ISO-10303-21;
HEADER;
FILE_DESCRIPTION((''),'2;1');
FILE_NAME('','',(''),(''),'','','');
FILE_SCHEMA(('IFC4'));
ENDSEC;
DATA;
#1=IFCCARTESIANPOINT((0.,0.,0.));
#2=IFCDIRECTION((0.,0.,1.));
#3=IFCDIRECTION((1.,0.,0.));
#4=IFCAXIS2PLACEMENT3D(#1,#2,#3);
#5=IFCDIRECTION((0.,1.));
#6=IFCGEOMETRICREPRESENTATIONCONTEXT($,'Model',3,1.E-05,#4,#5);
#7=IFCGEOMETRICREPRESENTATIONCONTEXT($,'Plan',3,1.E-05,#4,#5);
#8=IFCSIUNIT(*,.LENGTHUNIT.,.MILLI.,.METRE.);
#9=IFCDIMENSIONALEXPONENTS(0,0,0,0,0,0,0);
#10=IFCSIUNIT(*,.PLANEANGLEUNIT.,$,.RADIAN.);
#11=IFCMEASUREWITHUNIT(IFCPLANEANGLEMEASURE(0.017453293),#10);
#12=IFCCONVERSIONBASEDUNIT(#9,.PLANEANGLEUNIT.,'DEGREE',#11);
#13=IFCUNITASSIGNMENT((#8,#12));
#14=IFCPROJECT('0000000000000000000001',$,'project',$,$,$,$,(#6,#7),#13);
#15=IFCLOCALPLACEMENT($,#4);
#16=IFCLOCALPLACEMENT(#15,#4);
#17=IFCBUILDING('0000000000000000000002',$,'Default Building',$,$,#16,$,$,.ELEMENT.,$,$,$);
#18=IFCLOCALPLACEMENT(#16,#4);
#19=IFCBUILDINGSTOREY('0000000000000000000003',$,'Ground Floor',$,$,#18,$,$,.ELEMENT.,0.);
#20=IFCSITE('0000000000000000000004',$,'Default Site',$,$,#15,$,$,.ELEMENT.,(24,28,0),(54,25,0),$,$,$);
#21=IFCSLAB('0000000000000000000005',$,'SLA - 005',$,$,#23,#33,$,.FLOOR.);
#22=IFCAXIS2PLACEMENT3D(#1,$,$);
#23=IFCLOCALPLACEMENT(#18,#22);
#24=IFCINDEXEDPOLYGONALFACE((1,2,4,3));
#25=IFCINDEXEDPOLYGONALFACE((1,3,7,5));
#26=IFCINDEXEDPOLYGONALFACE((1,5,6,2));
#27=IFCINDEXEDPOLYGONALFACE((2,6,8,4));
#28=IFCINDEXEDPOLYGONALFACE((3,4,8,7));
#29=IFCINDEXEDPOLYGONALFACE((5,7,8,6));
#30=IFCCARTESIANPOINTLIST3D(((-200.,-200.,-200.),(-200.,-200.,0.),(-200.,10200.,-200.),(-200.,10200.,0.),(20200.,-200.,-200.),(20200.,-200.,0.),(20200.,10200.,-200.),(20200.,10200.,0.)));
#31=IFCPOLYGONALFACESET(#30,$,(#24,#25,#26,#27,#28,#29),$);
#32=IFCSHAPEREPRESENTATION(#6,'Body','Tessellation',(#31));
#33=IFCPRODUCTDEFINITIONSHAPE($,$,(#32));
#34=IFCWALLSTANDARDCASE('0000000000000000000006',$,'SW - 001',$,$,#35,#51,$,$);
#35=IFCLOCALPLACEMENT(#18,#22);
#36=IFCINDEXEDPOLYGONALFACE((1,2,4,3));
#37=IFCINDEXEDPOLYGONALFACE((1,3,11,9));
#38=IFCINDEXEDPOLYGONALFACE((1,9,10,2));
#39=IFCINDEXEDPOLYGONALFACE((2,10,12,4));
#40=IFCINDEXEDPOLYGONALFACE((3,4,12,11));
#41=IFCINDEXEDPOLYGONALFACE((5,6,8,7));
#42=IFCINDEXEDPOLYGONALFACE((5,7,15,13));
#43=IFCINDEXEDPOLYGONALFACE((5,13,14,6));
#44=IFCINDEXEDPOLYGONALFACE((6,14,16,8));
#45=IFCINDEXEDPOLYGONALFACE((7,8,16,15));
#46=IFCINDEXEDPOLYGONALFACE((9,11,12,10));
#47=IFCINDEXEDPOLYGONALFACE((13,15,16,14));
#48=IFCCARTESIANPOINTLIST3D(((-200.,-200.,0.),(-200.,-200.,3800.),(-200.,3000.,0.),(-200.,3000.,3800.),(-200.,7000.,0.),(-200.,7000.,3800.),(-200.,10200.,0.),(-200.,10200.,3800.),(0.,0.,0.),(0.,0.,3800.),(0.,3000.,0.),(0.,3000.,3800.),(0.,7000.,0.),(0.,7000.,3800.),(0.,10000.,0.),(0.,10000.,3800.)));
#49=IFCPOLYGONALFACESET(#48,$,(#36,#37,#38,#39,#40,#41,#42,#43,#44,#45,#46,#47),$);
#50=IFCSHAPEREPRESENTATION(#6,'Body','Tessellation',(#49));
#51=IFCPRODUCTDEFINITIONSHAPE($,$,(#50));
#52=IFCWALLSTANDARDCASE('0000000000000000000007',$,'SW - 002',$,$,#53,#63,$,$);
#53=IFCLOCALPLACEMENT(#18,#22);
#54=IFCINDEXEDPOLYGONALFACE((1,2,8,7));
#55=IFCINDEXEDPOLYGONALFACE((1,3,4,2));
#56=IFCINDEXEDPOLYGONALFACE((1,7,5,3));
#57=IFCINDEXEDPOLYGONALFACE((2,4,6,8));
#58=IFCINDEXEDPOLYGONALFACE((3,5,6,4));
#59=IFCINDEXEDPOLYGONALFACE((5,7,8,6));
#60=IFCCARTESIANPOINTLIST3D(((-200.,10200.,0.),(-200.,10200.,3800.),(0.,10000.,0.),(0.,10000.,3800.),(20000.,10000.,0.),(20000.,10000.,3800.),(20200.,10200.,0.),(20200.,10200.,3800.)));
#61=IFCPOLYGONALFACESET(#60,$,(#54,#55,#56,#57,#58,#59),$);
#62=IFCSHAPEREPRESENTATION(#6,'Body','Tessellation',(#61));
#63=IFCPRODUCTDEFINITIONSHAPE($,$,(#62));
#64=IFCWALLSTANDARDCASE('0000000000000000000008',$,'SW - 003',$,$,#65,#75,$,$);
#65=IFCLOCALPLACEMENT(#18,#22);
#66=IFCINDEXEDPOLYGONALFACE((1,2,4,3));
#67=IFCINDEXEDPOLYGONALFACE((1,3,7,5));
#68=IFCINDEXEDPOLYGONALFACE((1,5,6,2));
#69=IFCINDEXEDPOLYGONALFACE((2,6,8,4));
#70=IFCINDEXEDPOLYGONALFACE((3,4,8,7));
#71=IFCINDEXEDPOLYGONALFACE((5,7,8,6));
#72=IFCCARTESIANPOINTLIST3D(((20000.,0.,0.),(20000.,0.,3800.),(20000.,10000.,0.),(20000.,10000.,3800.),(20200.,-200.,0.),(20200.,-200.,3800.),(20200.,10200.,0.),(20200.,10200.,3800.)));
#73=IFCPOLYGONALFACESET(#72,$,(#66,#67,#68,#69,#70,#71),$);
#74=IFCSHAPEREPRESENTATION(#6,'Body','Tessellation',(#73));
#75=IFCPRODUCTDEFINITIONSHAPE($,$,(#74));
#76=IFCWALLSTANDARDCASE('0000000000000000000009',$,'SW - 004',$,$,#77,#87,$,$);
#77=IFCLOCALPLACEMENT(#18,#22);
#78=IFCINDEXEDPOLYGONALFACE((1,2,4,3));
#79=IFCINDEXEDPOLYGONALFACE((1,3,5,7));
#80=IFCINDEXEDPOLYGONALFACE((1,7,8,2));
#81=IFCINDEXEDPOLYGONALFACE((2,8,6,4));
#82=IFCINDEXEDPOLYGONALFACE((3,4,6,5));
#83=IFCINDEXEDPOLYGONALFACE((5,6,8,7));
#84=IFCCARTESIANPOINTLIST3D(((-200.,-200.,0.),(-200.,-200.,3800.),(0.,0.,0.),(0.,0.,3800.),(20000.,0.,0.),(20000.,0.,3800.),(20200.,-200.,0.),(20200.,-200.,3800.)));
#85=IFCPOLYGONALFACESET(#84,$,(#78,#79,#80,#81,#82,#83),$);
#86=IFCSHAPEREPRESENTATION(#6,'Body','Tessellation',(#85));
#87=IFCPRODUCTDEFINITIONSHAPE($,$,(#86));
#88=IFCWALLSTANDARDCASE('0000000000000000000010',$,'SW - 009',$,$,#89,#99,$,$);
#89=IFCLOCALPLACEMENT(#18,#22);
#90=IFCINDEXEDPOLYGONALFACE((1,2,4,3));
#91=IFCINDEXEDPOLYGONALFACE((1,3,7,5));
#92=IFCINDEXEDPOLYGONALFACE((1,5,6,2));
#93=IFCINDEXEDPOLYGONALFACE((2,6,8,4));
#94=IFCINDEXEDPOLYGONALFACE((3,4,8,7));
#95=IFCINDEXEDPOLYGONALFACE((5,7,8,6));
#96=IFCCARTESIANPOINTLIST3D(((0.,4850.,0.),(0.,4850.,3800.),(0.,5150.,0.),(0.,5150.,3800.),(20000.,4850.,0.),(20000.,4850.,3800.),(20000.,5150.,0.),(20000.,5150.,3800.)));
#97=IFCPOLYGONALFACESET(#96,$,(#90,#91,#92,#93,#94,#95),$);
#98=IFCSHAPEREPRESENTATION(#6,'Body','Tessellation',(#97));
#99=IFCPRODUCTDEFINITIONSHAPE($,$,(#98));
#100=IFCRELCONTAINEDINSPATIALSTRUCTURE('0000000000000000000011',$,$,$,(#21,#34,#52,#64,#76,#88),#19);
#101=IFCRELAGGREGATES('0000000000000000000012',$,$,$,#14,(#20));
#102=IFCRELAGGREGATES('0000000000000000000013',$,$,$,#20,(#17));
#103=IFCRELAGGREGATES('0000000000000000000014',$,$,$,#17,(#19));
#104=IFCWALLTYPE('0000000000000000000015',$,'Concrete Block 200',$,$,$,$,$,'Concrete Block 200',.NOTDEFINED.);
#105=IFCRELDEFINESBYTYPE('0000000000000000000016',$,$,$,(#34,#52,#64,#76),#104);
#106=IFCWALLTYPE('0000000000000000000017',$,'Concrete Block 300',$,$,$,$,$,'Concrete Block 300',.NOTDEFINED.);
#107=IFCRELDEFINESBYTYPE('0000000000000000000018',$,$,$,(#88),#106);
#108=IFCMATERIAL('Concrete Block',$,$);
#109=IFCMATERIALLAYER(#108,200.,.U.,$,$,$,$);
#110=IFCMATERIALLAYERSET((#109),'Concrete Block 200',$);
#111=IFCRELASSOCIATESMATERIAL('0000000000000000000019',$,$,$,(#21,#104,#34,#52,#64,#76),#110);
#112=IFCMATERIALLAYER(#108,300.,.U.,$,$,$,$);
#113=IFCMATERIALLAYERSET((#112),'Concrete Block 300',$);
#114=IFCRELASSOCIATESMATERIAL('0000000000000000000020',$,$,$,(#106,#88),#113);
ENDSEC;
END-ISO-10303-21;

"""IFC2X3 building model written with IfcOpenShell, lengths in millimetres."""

from ifc_helpers import new_model, entity, si_unit, converted_unit, direction, frame, frame_2d, origin_with_axes, place, context, project, spatial, polyline, rectangle, outline, extrude, material, layer, layer_set, layer_usage, type_object, element, save


model = new_model("IFC2X3")

# Units and contexts
model_context = context("Model", 3, precision=1e-05, world=origin_with_axes(), true_north=direction((0.0, 1.0)))
plan_context = context("Plan", 3, precision=1e-05, world=origin_with_axes(), true_north=direction((0.0, 1.0)))
ifc_project = project(units=[si_unit("LENGTHUNIT", "METRE", prefix="MILLI"), converted_unit("PLANEANGLEUNIT", "DEGREE", entity("IfcPlaneAngleMeasure", 0.017453293), si_unit("PLANEANGLEUNIT", "RADIAN"), dimensions=[0, 0, 0, 0, 0, 0, 0])], contexts=[model_context, plan_context])

# Site, building, storey
site_placement = place(None, origin_with_axes())
site = spatial("IfcSite", under=ifc_project, at=site_placement, Name="Default Site", CompositionType="ELEMENT", RefLatitude=(24, 28, 0), RefLongitude=(54, 25, 0))
building_placement = place(site_placement, origin_with_axes())
building = spatial("IfcBuilding", under=site, at=building_placement, Name="Default Building", CompositionType="ELEMENT")
storey_placement = place(building_placement, origin_with_axes())
storey = spatial("IfcBuildingStorey", under=building, at=storey_placement, Name="Ground Floor", CompositionType="ELEMENT", Elevation=0.0)

# Slab
ifc_material = material(Name="Concrete Block")
ifc_layer_1 = layer(ifc_material, 200.0, ventilated="UNKNOWN")
ifc_layer_set_1 = layer_set([ifc_layer_1], Name="Concrete Block 200")
ifc_layer_usage_1 = layer_usage(ifc_layer_set_1, "AXIS3", "NEGATIVE", 200.0)
slab_placement = place(storey_placement, frame((-200.0, 10200.0, -200.0), z_axis=(0.0, 0.0, 1.0), x_axis=(1.0, 0.0, 0.0)))
element("IfcSlab", 1, at=slab_placement, inside=storey, material=ifc_layer_usage_1, Name="SLA - 005", PredefinedType="FLOOR", context=model_context, shape_type="SweptSolid", body=[
    extrude(outline(polyline([(0.0, 0.0), (20400.0, 0.0), (20400.0, -10400.0), (0.0, -10400.0), (0.0, 0.0)])), origin_with_axes(), (0.0, 0.0, 1.0), 200.0),
])

# Wall, opening
ifc_layer_usage_2 = layer_usage(ifc_layer_set_1, "AXIS2", "POSITIVE", 0.0)
wall_type_1 = type_object("IfcWallType", Name="Concrete Block 200", ElementType="Concrete Block 200", PredefinedType="NOTDEFINED", material=ifc_layer_set_1)
wall_1_placement = place(storey_placement, frame((0.0, 0.0, 0.0), z_axis=(0.0, 0.0, 1.0), x_axis=(0.0, 1.0, 0.0)))
wall_1 = element("IfcWallStandardCase", 2, at=wall_1_placement, inside=storey, type_object=wall_type_1, material=ifc_layer_usage_2, Name="SW - 001", context=model_context, shape_type="SweptSolid", body=[
    extrude(outline(polyline([(0.0, 0.0), (10000.0, 0.0), (10200.0, 200.0), (-200.0, 200.0), (0.0, 0.0)])), origin_with_axes(), (0.0, 0.0, 1.0), 3800.0),
])
opening_placement = place(wall_1_placement, frame((5000.0, 0.0, 0.0), z_axis=(0.0, 0.0, 1.0), x_axis=(1.0, 0.0, 0.0)))
element("IfcOpeningElement", 3, at=opening_placement, cuts=wall_1, ObjectType="Opening", context=model_context, shape_type="SweptSolid", body=[
    extrude(rectangle(XDim=4000.0, YDim=3800.0, at=frame_2d((0.0, 1900.0), x_axis=(1.0, 0.0))), frame((0.0, 0.0, 0.0), z_axis=(0.0, 1.0, 0.0), x_axis=(-1.0, 0.0, 0.0)), (0.0, 0.0, 1.0), 200.0),
])

# Walls
ifc_layer_usage_3 = layer_usage(ifc_layer_set_1, "AXIS2", "POSITIVE", 0.0)
wall_2_placement = place(storey_placement, frame((0.0, 10000.0, 0.0), z_axis=(0.0, 0.0, 1.0), x_axis=(1.0, 0.0, 0.0)))
element("IfcWallStandardCase", 4, at=wall_2_placement, inside=storey, type_object=wall_type_1, material=ifc_layer_usage_3, Name="SW - 002", context=model_context, shape_type="SweptSolid", body=[
    extrude(outline(polyline([(0.0, 0.0), (20000.0, 0.0), (20200.0, 200.0), (-200.0, 200.0), (0.0, 0.0)])), origin_with_axes(), (0.0, 0.0, 1.0), 3800.0),
])
ifc_layer_usage_4 = layer_usage(ifc_layer_set_1, "AXIS2", "POSITIVE", 0.0)
wall_3_placement = place(storey_placement, frame((20000.0, 10000.0, 0.0), z_axis=(0.0, 0.0, 1.0), x_axis=(0.0, -1.0, 0.0)))
element("IfcWallStandardCase", 5, at=wall_3_placement, inside=storey, type_object=wall_type_1, material=ifc_layer_usage_4, Name="SW - 003", context=model_context, shape_type="SweptSolid", body=[
    extrude(outline(polyline([(0.0, 0.0), (10000.0, 0.0), (10200.0, 200.0), (-200.0, 200.0), (0.0, 0.0)])), origin_with_axes(), (0.0, 0.0, 1.0), 3800.0),
])
ifc_layer_usage_5 = layer_usage(ifc_layer_set_1, "AXIS2", "POSITIVE", 0.0)
wall_4_placement = place(storey_placement, frame((20000.0, 0.0, 0.0), z_axis=(0.0, 0.0, 1.0), x_axis=(-1.0, 0.0, 0.0)))
element("IfcWallStandardCase", 6, at=wall_4_placement, inside=storey, type_object=wall_type_1, material=ifc_layer_usage_5, Name="SW - 004", context=model_context, shape_type="SweptSolid", body=[
    extrude(outline(polyline([(0.0, 0.0), (20000.0, 0.0), (20200.0, 200.0), (-200.0, 200.0), (0.0, 0.0)])), origin_with_axes(), (0.0, 0.0, 1.0), 3800.0),
])
ifc_layer_2 = layer(ifc_material, 300.0, ventilated="UNKNOWN")
ifc_layer_set_2 = layer_set([ifc_layer_2], Name="Concrete Block 300")
ifc_layer_usage_6 = layer_usage(ifc_layer_set_2, "AXIS2", "NEGATIVE", 150.0)
wall_type_2 = type_object("IfcWallType", Name="Concrete Block 300", ElementType="Concrete Block 300", PredefinedType="NOTDEFINED", material=ifc_layer_set_2)
wall_5_placement = place(storey_placement, frame((0.0, 5000.0, 0.0), z_axis=(0.0, 0.0, 1.0), x_axis=(1.0, 0.0, 0.0)))
element("IfcWallStandardCase", 7, at=wall_5_placement, inside=storey, type_object=wall_type_2, material=ifc_layer_usage_6, Name="SW - 009", context=model_context, shape_type="SweptSolid", body=[
    extrude(outline(polyline([(0.0, -150.0), (20000.0, -150.0), (20000.0, 150.0), (0.0, 150.0), (0.0, -150.0)])), origin_with_axes(), (0.0, 0.0, 1.0), 3800.0),
])

save(model, "model.ifc")
